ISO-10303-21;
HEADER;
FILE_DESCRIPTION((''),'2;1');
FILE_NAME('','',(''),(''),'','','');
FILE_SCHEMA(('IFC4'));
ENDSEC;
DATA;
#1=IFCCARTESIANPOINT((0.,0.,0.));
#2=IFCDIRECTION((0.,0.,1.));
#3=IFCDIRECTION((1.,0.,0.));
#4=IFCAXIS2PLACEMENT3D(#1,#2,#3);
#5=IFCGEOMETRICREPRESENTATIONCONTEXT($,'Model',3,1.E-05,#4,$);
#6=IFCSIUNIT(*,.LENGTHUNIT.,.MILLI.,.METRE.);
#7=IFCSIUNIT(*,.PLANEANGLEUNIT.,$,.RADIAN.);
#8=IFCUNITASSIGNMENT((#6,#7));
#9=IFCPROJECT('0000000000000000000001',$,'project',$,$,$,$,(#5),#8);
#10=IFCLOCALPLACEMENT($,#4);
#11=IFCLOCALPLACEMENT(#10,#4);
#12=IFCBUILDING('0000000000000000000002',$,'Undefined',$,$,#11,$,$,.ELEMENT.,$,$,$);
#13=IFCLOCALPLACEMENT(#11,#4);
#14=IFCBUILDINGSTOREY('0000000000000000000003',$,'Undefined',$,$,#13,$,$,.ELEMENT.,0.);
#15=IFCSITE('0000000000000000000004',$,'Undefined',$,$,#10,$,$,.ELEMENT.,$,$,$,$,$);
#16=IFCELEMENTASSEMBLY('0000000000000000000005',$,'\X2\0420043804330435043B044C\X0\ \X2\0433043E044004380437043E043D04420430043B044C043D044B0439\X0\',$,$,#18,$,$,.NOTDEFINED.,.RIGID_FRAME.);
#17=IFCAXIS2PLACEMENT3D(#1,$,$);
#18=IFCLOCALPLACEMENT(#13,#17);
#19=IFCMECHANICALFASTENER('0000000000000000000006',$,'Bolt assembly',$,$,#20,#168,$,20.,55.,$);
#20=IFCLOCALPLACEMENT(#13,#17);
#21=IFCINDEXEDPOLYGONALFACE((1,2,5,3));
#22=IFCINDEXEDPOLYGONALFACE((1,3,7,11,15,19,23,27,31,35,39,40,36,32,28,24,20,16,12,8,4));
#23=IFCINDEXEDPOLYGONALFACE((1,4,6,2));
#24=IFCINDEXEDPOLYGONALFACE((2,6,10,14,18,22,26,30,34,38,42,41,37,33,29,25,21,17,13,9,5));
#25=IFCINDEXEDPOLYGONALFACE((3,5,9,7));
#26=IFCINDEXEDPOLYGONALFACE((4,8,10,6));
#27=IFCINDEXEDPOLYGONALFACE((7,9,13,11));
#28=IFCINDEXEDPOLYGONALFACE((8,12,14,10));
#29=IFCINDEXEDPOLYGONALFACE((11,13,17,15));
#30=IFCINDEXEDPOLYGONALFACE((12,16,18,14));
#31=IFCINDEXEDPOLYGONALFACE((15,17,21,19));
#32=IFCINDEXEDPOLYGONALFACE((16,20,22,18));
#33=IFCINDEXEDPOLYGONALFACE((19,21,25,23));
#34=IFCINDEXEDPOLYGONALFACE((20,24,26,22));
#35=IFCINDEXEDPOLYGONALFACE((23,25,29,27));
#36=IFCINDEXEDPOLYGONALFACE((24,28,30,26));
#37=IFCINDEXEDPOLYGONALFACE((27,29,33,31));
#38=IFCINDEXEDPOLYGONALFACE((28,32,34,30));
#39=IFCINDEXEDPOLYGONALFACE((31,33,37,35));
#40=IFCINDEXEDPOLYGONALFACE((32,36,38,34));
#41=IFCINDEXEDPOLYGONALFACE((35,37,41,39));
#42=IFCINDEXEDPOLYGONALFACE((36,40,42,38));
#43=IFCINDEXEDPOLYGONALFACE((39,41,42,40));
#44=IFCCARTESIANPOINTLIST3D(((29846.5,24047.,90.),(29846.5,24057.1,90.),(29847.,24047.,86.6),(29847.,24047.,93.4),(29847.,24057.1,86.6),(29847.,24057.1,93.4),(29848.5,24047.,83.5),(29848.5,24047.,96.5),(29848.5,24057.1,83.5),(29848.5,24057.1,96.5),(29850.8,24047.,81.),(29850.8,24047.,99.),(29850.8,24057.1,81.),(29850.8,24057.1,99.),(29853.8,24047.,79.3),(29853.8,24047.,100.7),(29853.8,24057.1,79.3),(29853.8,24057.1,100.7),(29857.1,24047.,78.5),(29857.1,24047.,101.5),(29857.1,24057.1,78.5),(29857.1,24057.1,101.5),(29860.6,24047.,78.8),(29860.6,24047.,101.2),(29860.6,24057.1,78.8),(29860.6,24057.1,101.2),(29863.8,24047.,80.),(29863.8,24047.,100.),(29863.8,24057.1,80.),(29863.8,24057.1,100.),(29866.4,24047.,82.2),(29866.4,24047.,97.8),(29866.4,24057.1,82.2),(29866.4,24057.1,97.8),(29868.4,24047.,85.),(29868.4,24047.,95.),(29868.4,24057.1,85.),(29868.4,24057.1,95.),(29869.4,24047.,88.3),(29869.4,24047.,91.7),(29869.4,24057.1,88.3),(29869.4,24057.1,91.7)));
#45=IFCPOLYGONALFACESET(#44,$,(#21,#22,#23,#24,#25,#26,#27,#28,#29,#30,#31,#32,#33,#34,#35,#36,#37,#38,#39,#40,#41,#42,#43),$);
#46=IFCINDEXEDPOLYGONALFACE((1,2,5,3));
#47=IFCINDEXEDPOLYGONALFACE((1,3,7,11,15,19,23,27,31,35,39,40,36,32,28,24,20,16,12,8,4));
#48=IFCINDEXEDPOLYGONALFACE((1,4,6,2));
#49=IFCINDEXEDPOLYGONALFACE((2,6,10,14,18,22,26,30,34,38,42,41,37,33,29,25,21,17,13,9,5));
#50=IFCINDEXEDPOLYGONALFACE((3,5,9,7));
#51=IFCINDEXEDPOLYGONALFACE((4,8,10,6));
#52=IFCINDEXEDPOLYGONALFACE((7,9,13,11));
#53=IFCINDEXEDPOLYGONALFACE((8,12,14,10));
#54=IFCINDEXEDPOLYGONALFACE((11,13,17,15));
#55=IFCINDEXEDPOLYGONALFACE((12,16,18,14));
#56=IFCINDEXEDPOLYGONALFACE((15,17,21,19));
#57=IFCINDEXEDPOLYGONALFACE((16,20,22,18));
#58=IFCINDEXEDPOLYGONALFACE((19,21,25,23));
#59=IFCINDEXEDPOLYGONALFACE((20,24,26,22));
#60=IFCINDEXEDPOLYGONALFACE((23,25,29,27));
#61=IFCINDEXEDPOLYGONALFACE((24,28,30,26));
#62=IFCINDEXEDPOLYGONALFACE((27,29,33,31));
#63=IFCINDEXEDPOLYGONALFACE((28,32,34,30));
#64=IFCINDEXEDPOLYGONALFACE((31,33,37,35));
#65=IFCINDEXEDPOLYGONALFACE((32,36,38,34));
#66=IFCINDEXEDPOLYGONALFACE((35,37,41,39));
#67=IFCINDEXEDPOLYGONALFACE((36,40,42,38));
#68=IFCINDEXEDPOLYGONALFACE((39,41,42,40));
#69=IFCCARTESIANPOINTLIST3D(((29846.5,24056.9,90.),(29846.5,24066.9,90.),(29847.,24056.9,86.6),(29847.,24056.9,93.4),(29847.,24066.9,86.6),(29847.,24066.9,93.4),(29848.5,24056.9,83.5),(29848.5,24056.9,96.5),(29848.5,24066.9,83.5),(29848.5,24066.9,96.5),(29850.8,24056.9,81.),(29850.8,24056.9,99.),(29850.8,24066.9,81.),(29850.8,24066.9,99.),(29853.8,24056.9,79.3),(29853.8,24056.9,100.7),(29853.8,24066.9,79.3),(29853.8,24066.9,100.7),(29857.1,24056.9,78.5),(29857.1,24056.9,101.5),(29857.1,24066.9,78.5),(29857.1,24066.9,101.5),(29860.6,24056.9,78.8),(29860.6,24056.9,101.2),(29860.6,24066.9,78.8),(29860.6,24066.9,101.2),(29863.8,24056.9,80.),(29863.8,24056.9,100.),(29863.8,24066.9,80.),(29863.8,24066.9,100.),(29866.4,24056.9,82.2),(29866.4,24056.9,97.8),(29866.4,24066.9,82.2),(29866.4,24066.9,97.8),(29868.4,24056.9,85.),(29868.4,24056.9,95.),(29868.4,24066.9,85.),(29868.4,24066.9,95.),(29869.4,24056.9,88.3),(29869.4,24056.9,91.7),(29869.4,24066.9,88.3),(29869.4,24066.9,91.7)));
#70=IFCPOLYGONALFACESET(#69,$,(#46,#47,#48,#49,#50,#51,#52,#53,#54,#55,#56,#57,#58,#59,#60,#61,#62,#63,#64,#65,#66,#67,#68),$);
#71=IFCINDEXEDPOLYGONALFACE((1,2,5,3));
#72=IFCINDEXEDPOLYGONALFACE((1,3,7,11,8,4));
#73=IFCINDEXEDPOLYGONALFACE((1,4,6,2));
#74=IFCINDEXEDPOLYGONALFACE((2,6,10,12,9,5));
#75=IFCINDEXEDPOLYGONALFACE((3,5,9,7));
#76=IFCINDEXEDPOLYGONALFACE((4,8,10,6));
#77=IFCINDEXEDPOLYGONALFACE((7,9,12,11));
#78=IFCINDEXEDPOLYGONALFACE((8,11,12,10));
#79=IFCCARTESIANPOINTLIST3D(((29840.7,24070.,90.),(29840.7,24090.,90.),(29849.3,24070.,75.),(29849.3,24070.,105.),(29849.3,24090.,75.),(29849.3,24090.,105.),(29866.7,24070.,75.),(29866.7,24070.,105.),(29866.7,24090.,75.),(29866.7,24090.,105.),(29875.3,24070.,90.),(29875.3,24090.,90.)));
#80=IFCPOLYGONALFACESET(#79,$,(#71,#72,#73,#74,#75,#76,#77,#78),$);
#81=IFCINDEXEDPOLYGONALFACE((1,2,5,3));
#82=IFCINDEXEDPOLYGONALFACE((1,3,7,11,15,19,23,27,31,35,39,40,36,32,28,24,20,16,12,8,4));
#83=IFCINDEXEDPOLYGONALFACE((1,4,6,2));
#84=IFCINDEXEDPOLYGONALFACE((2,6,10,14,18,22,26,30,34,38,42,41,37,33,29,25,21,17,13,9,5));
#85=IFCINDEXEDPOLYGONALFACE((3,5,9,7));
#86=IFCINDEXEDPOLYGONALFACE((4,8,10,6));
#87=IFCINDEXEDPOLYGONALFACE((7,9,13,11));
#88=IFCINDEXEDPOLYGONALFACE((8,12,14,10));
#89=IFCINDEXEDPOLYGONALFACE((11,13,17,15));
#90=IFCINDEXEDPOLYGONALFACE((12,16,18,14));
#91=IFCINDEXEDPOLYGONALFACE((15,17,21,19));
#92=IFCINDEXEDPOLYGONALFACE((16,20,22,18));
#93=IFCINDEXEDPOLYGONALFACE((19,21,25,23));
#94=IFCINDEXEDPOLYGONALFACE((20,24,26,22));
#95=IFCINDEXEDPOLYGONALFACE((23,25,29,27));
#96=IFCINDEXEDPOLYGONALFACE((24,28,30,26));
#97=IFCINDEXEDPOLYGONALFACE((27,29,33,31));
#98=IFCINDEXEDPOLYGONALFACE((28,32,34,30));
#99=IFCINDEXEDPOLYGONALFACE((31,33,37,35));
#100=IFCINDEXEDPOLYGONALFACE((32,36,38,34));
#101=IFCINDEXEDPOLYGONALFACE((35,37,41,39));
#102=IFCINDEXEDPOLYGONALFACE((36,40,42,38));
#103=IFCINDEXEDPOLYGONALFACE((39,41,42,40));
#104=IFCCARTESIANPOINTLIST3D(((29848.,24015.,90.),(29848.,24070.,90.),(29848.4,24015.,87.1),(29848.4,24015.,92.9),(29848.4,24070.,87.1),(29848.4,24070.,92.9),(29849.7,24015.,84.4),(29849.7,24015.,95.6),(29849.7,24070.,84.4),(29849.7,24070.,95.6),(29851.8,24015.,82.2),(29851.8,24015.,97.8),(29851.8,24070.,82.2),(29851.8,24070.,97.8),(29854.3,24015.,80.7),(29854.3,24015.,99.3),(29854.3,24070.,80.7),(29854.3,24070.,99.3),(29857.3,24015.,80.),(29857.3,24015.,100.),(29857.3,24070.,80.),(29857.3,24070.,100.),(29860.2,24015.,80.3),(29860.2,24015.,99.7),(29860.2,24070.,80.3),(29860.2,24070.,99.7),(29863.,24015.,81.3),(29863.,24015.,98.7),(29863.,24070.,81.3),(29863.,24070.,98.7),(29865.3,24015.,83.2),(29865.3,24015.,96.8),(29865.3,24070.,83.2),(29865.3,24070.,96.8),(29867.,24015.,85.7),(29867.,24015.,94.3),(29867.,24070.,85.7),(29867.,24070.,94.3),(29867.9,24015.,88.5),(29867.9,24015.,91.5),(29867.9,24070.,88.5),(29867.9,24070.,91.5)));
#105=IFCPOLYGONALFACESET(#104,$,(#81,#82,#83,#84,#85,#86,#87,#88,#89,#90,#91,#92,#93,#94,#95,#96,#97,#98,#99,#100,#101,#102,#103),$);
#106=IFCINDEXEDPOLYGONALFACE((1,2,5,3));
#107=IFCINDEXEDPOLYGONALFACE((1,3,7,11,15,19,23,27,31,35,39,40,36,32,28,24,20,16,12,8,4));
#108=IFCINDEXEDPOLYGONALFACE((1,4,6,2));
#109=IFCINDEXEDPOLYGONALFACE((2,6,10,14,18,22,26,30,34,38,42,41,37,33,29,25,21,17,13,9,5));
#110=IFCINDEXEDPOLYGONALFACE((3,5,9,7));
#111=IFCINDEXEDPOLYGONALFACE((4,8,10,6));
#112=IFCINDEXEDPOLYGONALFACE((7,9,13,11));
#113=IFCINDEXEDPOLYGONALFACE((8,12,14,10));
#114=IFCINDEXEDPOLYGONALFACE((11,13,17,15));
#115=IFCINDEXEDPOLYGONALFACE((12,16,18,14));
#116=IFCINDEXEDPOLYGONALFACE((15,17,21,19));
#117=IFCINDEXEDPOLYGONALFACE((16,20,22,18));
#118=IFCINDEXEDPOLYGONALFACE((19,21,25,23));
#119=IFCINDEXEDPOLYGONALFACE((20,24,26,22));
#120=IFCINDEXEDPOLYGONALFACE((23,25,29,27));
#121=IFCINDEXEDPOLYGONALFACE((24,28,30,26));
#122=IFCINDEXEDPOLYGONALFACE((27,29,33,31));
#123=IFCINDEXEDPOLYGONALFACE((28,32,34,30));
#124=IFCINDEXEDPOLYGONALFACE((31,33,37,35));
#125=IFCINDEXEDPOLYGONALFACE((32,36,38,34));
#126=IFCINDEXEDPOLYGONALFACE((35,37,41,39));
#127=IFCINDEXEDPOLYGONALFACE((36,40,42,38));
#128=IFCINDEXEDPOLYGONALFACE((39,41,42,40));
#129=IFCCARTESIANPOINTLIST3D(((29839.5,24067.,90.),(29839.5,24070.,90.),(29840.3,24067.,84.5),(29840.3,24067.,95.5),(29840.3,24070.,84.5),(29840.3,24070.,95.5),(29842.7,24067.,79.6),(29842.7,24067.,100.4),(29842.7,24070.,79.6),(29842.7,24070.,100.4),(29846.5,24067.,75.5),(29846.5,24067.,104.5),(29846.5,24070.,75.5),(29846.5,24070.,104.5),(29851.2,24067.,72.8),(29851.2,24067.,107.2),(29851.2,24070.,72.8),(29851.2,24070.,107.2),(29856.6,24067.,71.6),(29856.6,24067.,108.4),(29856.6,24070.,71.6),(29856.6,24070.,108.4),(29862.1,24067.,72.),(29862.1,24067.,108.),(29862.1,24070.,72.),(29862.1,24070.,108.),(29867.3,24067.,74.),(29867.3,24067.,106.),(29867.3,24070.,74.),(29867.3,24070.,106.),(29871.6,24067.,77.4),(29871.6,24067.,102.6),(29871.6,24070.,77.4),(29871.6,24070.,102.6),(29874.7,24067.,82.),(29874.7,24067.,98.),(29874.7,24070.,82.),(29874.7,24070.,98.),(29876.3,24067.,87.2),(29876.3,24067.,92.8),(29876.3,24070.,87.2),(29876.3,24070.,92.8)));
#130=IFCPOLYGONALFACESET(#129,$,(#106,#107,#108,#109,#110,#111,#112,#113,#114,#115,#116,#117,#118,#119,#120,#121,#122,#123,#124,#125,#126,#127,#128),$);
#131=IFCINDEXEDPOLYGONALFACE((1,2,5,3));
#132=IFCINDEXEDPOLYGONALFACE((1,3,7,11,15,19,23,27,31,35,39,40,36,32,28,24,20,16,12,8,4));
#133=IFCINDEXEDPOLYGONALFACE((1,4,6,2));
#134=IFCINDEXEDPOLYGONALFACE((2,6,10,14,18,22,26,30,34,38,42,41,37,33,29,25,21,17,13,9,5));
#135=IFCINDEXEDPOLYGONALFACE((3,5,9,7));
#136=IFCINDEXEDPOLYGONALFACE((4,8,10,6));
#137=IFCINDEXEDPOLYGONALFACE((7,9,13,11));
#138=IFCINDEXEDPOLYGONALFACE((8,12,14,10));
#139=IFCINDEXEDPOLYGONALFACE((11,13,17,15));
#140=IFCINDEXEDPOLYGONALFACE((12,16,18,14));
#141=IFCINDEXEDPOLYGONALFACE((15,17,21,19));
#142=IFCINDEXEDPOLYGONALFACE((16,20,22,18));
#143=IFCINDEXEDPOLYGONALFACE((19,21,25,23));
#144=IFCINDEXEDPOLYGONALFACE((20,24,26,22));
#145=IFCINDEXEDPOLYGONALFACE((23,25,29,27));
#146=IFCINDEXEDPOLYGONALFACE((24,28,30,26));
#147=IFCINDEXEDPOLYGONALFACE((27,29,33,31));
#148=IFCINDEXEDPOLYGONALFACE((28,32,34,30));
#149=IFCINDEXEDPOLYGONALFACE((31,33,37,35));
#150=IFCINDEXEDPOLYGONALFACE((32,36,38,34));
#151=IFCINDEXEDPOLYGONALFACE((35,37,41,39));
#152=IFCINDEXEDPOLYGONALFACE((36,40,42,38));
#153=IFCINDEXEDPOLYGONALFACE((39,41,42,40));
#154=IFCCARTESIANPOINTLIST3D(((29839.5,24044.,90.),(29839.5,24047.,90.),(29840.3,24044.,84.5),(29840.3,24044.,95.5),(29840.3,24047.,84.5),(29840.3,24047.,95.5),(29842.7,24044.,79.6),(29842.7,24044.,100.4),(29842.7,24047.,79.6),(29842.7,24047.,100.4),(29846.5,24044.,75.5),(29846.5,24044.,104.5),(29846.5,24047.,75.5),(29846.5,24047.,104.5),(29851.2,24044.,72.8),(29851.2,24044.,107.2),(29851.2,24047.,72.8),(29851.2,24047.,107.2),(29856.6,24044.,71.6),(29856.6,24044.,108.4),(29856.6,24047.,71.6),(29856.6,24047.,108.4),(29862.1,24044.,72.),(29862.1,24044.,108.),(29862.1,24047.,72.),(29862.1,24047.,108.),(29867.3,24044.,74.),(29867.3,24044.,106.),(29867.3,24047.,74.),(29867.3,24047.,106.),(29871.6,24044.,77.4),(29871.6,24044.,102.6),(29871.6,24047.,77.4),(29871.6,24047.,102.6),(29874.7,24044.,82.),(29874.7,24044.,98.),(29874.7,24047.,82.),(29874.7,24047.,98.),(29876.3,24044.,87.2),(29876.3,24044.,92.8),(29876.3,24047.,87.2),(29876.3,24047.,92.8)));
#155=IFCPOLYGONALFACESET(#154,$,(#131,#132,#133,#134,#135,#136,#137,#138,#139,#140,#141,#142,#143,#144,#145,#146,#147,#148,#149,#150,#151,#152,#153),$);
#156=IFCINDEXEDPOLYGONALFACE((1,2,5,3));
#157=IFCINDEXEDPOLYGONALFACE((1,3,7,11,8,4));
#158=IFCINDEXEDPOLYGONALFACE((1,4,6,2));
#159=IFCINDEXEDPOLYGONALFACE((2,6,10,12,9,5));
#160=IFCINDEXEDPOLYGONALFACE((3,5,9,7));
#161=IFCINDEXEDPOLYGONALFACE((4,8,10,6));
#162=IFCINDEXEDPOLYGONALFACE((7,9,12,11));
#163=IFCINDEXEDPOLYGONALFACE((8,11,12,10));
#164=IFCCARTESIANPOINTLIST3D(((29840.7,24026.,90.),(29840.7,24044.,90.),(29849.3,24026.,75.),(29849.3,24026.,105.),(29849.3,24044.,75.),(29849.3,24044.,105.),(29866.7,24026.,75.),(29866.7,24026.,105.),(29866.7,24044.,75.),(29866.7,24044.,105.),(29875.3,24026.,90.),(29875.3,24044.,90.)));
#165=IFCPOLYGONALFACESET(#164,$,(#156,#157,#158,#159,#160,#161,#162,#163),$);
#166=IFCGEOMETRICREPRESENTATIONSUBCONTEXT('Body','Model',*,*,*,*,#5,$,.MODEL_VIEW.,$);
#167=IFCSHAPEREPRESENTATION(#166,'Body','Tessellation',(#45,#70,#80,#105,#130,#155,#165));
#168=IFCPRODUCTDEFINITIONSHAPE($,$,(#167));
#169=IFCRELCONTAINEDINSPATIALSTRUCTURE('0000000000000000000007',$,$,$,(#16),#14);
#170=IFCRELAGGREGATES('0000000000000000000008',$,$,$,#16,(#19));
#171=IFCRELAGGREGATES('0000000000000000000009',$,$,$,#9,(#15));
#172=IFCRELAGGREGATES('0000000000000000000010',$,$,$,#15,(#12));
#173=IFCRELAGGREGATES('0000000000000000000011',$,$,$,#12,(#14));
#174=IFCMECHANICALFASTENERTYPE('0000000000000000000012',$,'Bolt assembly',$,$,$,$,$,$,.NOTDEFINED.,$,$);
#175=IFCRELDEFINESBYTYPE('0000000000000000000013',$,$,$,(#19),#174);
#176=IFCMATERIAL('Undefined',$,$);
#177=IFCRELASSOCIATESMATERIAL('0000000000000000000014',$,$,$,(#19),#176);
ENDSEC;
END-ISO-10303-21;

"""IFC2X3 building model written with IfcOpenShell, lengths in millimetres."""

from ifc_helpers import new_model, si_unit, frame, origin_with_axes, origin_2d_with_axis, place, context, subcontext, project, spatial, polyline, circle, outline, extrude, source, transform, mapped, material, type_object, element, aggregate, save


model = new_model("IFC2X3")

# Units and contexts
model_context = context("Model", 3, precision=1e-05, world=origin_with_axes())
body_context = subcontext(model_context, "Body", "Model", "MODEL_VIEW")
ifc_project = project(units=[si_unit("LENGTHUNIT", "METRE", prefix="MILLI"), si_unit("PLANEANGLEUNIT", "RADIAN")], contexts=[model_context])

# Site, building, storey
site_placement = place(None, origin_with_axes())
site = spatial("IfcSite", under=ifc_project, at=site_placement, Name="Undefined", CompositionType="ELEMENT")
building_placement = place(site_placement, origin_with_axes())
building = spatial("IfcBuilding", under=site, at=building_placement, Name="Undefined", CompositionType="ELEMENT")
storey_placement = place(building_placement, origin_with_axes())
storey = spatial("IfcBuildingStorey", under=building, at=storey_placement, Name="Undefined", CompositionType="ELEMENT", Elevation=0.0)

# Element assembly
assembly_1_placement = place(storey_placement, origin_with_axes())
assembly_1 = element("IfcElementAssembly", 1, at=assembly_1_placement, inside=storey, Name="Ригель горизонтальный", AssemblyPlace="NOTDEFINED", PredefinedType="RIGID_FRAME")

# Mechanical fastener
ifc_material_1 = material(Name="Undefined")
mechanical_fastener_type = type_object("IfcMechanicalFastenerType", Name="Bolt assembly")
shared_shape_1 = source(origin_with_axes(), body_context, "Body", "SweptSolid", [
    extrude(circle(Radius=11.5, at=origin_2d_with_axis()), frame((0.0, -0.1, 0.0), z_axis=(0.0, 1.0, 0.0), x_axis=(1.0, 0.0, 0.0)), (0.0, 0.0, 1.0), 10.1),
    extrude(circle(Radius=11.5, at=origin_2d_with_axis()), frame((0.0, -9.9, 0.0), z_axis=(0.0, 1.0, 0.0), x_axis=(1.0, 0.0, 0.0)), (0.0, 0.0, 1.0), 10.0),
    extrude(outline(polyline([(17.3, 0.0), (8.7, 15.0), (-8.7, 15.0), (-17.3, 0.0), (-8.7, -15.0), (8.7, -15.0), (17.3, 0.0)])), frame((0.0, -33.0, 0.0), z_axis=(0.0, 1.0, 0.0), x_axis=(1.0, 0.0, 0.0)), (0.0, 0.0, 1.0), 20.0),
    extrude(circle(Radius=10.0, at=origin_2d_with_axis()), frame((0.0, -13.0, 0.0), z_axis=(0.0, 1.0, 0.0), x_axis=(1.0, 0.0, 0.0)), (0.0, 0.0, 1.0), 55.0),
    extrude(circle(Radius=18.5, at=origin_2d_with_axis()), frame((0.0, -13.0, 0.0), z_axis=(0.0, 1.0, 0.0), x_axis=(1.0, 0.0, 0.0)), (0.0, 0.0, 1.0), 3.0),
    extrude(circle(Radius=18.5, at=origin_2d_with_axis()), frame((0.0, 10.0, 0.0), z_axis=(0.0, 1.0, 0.0), x_axis=(1.0, 0.0, 0.0)), (0.0, 0.0, 1.0), 3.0),
    extrude(outline(polyline([(17.3, 0.0), (8.7, 15.0), (-8.7, 15.0), (-17.3, 0.0), (-8.7, -15.0), (8.7, -15.0), (17.3, 0.0)])), frame((0.0, 13.0, 0.0), z_axis=(0.0, 1.0, 0.0), x_axis=(1.0, 0.0, 0.0)), (0.0, 0.0, 1.0), 18.0),
])
mechanical_fastener_1_placement = place(assembly_1_placement, frame((29858.0, 24057.0, 90.0), z_axis=(0.0, 0.0, 1.0), x_axis=(-1.0, 0.0, 0.0)))
mechanical_fastener_1 = element("IfcMechanicalFastener", 2, at=mechanical_fastener_1_placement, type_object=mechanical_fastener_type, material=ifc_material_1, Name="Bolt assembly", NominalDiameter=20.0, NominalLength=55.0, context=body_context, shape_type="MappedRepresentation", body=[
    mapped(shared_shape_1, transform((0.0, 0.0, 0.0))),
])
aggregate(assembly_1, [mechanical_fastener_1])

save(model, "model.ifc")
